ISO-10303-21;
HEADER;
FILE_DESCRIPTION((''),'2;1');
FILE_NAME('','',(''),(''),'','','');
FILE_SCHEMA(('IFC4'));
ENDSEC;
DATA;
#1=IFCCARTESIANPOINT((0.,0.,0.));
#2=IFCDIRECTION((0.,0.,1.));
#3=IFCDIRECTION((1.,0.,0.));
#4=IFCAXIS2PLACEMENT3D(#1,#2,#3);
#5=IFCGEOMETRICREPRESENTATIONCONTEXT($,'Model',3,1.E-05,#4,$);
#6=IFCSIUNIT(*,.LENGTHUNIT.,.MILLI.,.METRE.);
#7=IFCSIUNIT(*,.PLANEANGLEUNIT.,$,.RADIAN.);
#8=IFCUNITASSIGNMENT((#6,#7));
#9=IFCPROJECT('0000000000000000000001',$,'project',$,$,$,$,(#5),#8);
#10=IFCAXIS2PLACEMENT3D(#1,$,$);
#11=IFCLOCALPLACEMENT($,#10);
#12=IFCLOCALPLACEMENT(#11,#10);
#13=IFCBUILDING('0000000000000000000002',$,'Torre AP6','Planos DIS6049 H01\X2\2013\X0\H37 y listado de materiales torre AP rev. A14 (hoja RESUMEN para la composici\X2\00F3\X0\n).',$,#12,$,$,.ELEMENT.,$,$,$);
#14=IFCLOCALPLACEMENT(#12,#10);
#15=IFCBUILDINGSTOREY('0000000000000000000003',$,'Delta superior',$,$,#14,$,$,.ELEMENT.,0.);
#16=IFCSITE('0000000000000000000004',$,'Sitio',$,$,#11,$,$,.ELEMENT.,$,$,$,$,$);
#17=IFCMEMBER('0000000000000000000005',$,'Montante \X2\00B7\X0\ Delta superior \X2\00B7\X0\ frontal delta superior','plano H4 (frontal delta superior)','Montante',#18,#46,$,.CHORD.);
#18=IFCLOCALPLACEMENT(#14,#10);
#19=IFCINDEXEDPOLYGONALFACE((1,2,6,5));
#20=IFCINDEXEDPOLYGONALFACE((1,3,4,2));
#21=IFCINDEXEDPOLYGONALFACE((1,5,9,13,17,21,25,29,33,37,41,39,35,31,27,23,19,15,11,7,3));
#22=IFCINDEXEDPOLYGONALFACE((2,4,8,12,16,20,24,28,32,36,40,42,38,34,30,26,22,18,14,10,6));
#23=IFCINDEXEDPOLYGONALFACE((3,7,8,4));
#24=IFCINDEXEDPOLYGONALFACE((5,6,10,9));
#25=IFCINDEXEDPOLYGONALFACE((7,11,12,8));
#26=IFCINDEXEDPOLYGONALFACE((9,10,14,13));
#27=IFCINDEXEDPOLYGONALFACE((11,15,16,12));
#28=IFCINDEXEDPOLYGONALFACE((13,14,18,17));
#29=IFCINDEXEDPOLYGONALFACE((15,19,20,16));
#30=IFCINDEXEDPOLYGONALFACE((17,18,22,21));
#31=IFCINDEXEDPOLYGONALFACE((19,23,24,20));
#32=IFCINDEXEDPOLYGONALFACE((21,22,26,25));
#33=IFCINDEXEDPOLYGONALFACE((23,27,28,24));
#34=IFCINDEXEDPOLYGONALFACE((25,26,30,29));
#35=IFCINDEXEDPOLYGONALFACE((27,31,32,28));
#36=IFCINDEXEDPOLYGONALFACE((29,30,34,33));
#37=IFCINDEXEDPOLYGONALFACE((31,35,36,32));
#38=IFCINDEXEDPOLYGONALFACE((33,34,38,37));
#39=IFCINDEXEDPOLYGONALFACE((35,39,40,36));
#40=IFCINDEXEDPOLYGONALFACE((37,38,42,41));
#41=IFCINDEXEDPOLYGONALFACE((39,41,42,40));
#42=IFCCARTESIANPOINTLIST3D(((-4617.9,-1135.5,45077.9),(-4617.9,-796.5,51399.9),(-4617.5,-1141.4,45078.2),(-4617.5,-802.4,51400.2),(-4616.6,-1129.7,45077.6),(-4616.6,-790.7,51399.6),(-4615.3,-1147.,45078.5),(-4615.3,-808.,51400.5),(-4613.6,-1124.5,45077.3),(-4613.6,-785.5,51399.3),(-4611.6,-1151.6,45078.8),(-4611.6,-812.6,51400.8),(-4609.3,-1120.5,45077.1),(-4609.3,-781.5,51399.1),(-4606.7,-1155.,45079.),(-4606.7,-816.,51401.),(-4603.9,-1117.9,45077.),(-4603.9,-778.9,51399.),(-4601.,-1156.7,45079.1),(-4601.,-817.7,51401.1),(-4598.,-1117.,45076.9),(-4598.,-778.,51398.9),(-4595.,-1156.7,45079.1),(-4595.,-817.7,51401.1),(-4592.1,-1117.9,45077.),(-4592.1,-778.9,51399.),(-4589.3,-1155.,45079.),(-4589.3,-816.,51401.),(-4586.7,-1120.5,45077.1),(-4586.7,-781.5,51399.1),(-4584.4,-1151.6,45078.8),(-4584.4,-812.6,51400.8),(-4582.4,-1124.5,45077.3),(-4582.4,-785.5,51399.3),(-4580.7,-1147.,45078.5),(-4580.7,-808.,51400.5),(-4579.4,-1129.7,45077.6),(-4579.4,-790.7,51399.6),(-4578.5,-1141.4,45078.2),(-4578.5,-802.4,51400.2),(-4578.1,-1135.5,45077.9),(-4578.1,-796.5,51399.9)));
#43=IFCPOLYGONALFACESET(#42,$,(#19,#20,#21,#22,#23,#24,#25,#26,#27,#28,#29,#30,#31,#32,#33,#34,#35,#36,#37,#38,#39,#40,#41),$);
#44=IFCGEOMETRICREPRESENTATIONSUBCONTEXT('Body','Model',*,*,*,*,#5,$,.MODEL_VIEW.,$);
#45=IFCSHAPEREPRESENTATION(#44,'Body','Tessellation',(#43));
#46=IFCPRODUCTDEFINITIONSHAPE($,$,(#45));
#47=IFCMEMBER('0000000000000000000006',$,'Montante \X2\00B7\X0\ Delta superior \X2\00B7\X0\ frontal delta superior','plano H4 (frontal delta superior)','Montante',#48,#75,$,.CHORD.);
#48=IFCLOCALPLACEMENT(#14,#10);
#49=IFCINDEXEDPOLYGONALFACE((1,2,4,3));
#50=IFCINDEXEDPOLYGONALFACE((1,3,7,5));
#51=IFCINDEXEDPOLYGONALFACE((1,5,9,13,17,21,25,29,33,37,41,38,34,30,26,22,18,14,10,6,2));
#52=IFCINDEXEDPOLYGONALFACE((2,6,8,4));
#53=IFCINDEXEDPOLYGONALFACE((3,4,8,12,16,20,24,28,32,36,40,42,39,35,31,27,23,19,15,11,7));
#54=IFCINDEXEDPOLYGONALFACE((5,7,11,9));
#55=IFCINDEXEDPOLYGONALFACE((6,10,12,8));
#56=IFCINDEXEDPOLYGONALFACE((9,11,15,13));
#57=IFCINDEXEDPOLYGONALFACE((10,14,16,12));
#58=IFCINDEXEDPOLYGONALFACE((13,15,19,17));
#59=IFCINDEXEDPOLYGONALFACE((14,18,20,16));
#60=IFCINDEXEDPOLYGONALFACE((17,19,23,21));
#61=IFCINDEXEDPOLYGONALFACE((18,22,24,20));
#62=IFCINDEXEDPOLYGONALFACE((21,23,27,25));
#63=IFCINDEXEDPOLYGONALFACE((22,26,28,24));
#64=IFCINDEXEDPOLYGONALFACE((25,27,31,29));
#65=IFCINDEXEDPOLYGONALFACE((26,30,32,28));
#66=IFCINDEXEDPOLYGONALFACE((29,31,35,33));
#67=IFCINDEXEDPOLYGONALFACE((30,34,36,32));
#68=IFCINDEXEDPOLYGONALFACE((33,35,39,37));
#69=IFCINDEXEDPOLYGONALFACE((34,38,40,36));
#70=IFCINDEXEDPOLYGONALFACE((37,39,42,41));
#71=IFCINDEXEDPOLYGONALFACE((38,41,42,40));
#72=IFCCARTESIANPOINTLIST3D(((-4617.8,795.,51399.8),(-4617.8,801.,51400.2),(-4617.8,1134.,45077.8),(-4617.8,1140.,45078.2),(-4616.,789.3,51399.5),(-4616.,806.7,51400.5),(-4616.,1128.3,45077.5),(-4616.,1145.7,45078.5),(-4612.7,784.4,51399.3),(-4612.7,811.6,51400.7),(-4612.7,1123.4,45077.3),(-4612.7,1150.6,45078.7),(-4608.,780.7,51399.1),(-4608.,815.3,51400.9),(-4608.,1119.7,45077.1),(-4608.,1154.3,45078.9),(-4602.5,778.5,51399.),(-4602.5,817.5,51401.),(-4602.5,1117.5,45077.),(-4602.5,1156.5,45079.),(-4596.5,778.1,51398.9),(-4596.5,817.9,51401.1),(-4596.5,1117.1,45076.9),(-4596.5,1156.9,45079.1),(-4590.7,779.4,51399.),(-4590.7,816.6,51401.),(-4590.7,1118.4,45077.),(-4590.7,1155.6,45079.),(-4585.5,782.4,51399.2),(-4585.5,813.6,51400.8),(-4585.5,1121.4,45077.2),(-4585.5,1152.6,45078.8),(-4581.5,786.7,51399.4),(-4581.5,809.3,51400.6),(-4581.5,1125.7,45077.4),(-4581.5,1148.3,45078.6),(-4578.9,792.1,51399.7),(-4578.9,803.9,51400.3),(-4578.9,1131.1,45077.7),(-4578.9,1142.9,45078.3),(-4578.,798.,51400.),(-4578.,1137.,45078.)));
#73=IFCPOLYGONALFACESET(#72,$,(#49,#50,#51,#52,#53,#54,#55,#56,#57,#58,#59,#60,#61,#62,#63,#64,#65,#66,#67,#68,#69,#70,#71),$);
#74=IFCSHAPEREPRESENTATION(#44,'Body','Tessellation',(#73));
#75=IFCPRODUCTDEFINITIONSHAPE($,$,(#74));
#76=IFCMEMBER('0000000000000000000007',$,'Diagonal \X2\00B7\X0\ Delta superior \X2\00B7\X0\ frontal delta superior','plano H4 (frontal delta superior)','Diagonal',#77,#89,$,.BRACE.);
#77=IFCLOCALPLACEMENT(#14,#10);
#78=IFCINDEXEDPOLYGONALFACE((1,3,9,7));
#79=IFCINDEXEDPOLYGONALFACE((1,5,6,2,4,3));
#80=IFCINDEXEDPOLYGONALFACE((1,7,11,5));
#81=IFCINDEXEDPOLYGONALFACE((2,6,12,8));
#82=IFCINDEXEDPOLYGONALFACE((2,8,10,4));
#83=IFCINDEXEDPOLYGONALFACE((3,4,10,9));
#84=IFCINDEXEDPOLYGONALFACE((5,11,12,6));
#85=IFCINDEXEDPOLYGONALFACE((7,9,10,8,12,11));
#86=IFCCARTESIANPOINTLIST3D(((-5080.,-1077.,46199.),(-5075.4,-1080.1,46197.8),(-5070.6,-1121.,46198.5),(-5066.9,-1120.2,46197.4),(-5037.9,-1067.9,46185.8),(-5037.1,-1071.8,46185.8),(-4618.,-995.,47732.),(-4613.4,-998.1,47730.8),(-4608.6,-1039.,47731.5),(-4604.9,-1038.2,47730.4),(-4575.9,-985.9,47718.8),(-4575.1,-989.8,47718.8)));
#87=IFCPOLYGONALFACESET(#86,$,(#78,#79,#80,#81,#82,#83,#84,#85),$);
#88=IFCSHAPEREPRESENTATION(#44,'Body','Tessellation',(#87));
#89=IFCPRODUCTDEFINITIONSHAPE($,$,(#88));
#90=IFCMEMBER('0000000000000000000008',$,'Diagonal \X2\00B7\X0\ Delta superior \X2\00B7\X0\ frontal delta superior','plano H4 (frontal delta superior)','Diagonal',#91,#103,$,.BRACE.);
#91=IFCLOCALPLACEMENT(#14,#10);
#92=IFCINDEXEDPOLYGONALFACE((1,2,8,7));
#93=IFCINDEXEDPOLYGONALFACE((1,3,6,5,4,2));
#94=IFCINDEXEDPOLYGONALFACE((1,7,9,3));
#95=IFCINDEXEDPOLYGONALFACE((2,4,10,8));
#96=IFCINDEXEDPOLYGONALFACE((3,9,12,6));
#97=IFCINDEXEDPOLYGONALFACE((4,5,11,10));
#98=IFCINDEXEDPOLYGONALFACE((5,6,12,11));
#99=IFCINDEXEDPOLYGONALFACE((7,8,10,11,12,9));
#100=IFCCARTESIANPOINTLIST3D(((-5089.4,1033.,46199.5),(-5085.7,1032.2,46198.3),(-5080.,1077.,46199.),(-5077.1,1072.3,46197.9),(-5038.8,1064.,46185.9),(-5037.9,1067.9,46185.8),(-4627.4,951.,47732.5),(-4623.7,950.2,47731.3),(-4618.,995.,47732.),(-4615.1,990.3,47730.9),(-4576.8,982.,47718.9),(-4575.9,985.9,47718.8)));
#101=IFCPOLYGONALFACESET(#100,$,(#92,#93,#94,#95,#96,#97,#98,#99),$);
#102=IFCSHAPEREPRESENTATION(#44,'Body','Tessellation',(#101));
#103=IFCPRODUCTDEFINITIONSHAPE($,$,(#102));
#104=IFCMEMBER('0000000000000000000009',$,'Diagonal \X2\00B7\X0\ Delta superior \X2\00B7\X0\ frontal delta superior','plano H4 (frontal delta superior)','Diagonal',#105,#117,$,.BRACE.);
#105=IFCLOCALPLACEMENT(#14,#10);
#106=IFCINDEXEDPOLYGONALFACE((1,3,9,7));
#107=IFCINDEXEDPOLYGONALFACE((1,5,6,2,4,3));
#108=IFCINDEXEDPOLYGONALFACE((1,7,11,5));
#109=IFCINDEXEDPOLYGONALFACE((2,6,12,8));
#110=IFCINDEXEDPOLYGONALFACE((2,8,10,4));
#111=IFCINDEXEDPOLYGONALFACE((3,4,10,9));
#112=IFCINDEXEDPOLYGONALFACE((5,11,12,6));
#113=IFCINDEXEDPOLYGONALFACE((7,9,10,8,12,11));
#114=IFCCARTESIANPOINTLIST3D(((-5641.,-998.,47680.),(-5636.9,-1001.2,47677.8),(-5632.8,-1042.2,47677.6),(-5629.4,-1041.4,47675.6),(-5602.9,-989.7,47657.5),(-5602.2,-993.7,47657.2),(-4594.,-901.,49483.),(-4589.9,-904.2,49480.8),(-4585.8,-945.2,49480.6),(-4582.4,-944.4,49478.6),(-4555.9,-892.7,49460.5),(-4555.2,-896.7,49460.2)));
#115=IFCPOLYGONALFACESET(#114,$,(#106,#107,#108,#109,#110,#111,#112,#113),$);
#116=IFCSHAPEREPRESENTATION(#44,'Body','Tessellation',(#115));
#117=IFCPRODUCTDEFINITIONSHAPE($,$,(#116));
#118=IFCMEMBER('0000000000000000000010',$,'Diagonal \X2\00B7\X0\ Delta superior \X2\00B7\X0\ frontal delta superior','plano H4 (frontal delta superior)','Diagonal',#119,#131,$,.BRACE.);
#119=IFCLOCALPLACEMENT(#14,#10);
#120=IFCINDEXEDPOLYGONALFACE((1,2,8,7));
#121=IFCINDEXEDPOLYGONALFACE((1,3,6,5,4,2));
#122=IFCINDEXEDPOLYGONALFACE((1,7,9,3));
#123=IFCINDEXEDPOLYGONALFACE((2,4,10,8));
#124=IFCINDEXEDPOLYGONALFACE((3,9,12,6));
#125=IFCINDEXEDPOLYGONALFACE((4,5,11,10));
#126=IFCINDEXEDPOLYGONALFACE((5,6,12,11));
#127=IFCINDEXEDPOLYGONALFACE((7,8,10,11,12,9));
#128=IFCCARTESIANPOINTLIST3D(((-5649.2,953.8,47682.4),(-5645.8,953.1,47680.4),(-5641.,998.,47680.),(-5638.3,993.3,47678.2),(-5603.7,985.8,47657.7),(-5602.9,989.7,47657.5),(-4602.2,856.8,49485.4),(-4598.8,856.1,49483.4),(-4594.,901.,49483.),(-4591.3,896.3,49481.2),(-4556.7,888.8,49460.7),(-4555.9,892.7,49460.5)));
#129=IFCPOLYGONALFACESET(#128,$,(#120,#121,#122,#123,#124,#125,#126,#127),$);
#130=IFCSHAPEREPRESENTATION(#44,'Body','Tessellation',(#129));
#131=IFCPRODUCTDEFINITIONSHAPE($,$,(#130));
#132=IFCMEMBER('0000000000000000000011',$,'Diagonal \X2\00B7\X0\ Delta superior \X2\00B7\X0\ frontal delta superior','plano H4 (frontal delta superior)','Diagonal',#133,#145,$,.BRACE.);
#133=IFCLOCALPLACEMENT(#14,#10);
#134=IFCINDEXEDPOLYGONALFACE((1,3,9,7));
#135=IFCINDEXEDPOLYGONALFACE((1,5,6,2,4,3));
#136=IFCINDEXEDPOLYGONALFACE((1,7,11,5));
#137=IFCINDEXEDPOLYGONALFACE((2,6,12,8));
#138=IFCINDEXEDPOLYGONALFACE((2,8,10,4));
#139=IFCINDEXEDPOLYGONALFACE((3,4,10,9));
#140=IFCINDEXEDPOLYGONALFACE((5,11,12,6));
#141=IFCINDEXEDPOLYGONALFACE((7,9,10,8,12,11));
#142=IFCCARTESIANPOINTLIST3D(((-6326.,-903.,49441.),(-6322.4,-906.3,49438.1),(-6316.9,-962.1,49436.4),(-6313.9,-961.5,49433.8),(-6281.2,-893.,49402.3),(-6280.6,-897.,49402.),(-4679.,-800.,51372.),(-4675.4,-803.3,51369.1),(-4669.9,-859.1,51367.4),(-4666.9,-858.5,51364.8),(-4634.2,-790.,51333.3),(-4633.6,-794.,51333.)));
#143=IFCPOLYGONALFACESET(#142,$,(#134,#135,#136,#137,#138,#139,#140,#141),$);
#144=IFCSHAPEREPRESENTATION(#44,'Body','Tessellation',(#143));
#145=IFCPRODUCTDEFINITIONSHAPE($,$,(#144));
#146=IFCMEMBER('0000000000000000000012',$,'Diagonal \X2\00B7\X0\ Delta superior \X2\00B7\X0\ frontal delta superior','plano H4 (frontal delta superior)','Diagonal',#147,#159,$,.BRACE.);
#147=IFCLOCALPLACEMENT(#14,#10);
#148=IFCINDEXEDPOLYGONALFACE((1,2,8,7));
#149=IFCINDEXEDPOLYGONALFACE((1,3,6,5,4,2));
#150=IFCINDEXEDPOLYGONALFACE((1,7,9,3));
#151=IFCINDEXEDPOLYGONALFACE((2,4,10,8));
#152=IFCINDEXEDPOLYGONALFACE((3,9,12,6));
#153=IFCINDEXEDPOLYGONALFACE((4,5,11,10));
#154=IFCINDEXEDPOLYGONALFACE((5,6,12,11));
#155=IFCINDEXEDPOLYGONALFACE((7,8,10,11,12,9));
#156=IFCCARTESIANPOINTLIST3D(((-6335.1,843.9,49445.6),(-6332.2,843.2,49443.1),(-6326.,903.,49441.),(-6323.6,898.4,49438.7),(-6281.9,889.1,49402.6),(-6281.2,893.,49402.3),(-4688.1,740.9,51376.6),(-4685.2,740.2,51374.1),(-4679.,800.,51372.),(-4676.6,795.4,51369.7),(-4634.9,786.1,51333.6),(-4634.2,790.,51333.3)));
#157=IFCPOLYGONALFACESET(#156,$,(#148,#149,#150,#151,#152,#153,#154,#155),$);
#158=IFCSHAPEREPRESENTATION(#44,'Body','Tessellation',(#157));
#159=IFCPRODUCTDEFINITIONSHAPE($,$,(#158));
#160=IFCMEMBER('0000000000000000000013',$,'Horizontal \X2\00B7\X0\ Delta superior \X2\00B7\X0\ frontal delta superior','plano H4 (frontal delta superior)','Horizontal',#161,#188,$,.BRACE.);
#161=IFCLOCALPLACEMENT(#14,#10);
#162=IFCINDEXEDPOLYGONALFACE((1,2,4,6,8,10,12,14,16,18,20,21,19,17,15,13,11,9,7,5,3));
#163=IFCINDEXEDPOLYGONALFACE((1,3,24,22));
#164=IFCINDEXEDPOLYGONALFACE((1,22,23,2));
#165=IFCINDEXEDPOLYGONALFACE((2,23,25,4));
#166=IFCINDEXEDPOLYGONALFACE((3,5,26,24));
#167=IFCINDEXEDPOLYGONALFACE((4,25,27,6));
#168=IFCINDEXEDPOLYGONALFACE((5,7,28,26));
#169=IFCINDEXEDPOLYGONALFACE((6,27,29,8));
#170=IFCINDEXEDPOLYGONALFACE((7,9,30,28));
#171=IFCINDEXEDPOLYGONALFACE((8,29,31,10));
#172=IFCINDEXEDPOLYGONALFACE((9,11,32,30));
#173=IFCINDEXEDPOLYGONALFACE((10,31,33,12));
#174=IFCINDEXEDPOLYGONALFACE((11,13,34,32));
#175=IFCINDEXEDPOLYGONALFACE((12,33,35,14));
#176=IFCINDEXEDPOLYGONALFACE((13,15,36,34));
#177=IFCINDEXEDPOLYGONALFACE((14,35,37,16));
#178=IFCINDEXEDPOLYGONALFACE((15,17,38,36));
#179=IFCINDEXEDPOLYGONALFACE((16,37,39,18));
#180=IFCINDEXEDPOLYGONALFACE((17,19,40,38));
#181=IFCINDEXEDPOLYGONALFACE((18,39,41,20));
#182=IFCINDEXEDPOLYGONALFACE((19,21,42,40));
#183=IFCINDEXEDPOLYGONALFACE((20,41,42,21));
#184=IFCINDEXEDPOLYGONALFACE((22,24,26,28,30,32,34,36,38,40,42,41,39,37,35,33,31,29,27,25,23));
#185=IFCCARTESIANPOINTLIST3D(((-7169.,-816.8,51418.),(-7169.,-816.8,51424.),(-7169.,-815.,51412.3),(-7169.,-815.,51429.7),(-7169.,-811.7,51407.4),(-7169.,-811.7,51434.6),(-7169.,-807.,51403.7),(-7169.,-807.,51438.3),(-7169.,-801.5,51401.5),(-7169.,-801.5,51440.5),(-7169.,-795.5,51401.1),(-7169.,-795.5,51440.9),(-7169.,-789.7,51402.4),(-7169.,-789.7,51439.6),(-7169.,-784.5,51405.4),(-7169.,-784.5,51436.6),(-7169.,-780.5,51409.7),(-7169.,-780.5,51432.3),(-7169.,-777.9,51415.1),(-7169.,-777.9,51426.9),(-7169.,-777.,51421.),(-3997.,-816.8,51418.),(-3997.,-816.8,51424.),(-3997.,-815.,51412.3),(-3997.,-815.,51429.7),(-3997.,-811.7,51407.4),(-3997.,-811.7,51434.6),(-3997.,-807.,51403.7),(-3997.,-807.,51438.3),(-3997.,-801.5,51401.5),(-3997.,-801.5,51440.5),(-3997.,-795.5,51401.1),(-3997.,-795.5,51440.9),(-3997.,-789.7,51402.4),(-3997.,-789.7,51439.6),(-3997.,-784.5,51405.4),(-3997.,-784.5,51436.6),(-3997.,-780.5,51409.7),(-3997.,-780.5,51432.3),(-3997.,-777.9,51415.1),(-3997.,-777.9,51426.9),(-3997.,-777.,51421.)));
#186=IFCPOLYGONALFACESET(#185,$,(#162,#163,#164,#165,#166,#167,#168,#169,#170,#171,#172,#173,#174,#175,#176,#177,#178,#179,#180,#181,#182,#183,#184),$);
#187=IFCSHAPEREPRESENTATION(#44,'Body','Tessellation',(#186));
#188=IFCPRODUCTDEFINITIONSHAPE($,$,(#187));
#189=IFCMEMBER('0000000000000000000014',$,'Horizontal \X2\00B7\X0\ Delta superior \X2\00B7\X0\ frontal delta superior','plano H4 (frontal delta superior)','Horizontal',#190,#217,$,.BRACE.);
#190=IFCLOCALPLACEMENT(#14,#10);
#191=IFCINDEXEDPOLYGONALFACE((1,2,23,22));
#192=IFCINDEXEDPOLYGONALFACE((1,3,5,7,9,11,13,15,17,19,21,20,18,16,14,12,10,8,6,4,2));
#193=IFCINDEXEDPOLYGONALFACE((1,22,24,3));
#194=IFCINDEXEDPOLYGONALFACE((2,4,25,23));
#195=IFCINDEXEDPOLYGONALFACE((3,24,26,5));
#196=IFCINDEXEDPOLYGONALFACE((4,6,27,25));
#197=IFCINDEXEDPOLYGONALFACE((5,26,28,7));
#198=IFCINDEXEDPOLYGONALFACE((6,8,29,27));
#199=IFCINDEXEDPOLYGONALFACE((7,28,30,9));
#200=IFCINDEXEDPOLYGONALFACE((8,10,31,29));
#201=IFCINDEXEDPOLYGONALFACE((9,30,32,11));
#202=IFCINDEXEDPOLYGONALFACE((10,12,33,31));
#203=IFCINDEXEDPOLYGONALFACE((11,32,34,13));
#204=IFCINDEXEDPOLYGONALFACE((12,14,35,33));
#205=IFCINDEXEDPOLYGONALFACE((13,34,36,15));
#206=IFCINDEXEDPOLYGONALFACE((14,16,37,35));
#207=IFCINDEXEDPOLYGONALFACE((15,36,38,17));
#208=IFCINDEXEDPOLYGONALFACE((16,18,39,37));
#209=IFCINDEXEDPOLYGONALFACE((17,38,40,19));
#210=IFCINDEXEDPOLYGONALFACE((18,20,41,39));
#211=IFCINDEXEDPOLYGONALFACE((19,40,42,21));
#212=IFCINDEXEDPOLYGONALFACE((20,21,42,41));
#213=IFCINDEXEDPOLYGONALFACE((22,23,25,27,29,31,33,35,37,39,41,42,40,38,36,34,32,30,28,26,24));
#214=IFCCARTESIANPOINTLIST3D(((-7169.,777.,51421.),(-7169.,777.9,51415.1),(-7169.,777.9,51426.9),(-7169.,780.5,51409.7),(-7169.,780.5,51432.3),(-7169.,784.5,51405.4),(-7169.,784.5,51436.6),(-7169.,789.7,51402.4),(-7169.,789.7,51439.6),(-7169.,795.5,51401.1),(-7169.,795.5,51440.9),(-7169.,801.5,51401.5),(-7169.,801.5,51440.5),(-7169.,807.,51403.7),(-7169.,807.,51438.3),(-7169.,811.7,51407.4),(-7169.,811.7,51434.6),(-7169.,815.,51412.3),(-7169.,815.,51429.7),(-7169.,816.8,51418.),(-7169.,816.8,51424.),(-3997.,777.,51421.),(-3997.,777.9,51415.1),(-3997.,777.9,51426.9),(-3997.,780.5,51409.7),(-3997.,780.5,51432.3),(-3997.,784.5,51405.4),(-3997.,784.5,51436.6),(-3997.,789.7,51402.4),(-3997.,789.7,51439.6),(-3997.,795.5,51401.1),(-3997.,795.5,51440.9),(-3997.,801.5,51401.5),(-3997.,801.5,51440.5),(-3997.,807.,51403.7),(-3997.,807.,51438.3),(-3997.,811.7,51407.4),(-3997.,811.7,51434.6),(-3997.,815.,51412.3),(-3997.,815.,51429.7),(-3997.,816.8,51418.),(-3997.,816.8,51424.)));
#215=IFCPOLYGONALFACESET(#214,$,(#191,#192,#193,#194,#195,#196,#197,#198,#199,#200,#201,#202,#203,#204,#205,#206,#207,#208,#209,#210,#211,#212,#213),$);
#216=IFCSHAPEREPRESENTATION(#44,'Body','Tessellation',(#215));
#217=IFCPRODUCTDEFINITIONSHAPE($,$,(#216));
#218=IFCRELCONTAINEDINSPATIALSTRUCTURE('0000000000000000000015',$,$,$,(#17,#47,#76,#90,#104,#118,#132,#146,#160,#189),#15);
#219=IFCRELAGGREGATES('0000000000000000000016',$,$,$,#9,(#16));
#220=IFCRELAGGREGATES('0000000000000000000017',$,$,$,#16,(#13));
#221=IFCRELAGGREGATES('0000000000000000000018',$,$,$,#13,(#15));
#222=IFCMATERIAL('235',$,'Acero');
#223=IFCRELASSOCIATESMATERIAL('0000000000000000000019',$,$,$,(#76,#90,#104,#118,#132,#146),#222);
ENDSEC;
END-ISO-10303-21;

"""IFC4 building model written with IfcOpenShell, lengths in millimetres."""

from ifc_helpers import new_model, si_unit, frame, frame_2d, origin, origin_with_axes, place, context, subcontext, project, spatial, circle, l_section, extrude, material, element, save


model = new_model("IFC4")

# Units and contexts
model_context = context("Model", 3, precision=1e-05, world=origin_with_axes())
body_context = subcontext(model_context, "Body", "Model", "MODEL_VIEW")
ifc_project = project(units=[si_unit("LENGTHUNIT", "METRE", prefix="MILLI"), si_unit("PLANEANGLEUNIT", "RADIAN")], contexts=[model_context])

# Site, building, storey
site_placement = place(None, origin())
site = spatial("IfcSite", under=ifc_project, at=site_placement, Name="Sitio", CompositionType="ELEMENT")
building_placement = place(site_placement, origin())
building = spatial("IfcBuilding", under=site, at=building_placement, Name="Torre AP6", Description="Planos DIS6049 H01–H37 y listado de materiales torre AP rev. A14 (hoja RESUMEN para la composición).", CompositionType="ELEMENT")
storey_placement = place(building_placement, origin())
storey = spatial("IfcBuildingStorey", under=building, at=storey_placement, Name="Delta superior", CompositionType="ELEMENT", Elevation=0.0)

# Members
for number, where, z_axis, x_axis, name in (
    (1, (-4598.0, -798.0, 51400.0), (0.0, -0.053545, -0.998565), (0.0, 0.998565, -0.053545), "Montante · Delta superior · frontal delta superior"),
    (2, (-4598.0, 798.0, 51400.0), (0.0, 0.053545, -0.998565), (1.0, 0.0, 0.0), "Montante · Delta superior · frontal delta superior"),
):
    element("IfcMember", number, at=place(storey_placement, frame(where, z_axis=z_axis, x_axis=x_axis)), inside=storey, Name=name, Description="plano H4 (frontal delta superior)", ObjectType="Montante", PredefinedType="CHORD", context=body_context, shape_type="SweptSolid", body=[
        extrude(circle(Radius=20.0), None, (0.0, 0.0, 1.0), 6331.1),
    ])
ifc_material_1 = material(Name="235", Category="Acero")
for number, where, z_axis, x_axis, name in (
    (3, (-4618.0, -995.0, 47732.0), (-0.288173, -0.051148, -0.956211), (0.934509, 0.202848, -0.292483), "Diagonal · Delta superior · frontal delta superior"),
    (4, (-4618.0, 995.0, 47732.0), (-0.288173, 0.051148, -0.956211), (0.934509, -0.202848, -0.292483), "Diagonal · Delta superior · frontal delta superior"),
):
    element("IfcMember", number, at=place(storey_placement, frame(where, z_axis=z_axis, x_axis=x_axis)), inside=storey, material=ifc_material_1, Name=name, Description="plano H4 (frontal delta superior)", ObjectType="Diagonal", PredefinedType="BRACE", context=body_context, shape_type="SweptSolid", body=[
        extrude(l_section(Depth=45.0, Width=45.0, Thickness=4.0, at=frame_2d((22.5, 22.5))), None, (0.0, 0.0, 1.0), 1603.2),
    ])
for number, where, z_axis, x_axis, name in (
    (5, (-4594.0, -901.0, 49483.0), (-0.501628, -0.046474, -0.863834), (0.845685, 0.183933, -0.500984), "Diagonal · Delta superior · frontal delta superior"),
    (6, (-4594.0, 901.0, 49483.0), (-0.501628, 0.046474, -0.863834), (0.845685, -0.183933, -0.500984), "Diagonal · Delta superior · frontal delta superior"),
):
    element("IfcMember", number, at=place(storey_placement, frame(where, z_axis=z_axis, x_axis=x_axis)), inside=storey, material=ifc_material_1, Name=name, Description="plano H4 (frontal delta superior)", ObjectType="Diagonal", PredefinedType="BRACE", context=body_context, shape_type="SweptSolid", body=[
        extrude(l_section(Depth=45.0, Width=45.0, Thickness=4.0, at=frame_2d((22.5, 22.5))), None, (0.0, 0.0, 1.0), 2087.2),
    ])
for number, where, z_axis, x_axis, name in (
    (7, (-4679.0, -800.0, 51372.0), (-0.648406, -0.04055, -0.760214), (0.745871, 0.166153, -0.645035), "Diagonal · Delta superior · frontal delta superior"),
    (8, (-4679.0, 800.0, 51372.0), (-0.648406, 0.04055, -0.760214), (0.745871, -0.166153, -0.645035), "Diagonal · Delta superior · frontal delta superior"),
):
    element("IfcMember", number, at=place(storey_placement, frame(where, z_axis=z_axis, x_axis=x_axis)), inside=storey, material=ifc_material_1, Name=name, Description="plano H4 (frontal delta superior)", ObjectType="Diagonal", PredefinedType="BRACE", context=body_context, shape_type="SweptSolid", body=[
        extrude(l_section(Depth=60.0, Width=60.0, Thickness=4.0, at=frame_2d((30.0, 30.0))), None, (0.0, 0.0, 1.0), 2540.1),
    ])
for number, where, z_axis, x_axis, name in (
    (9, (-3997.0, -797.0, 51421.0), (-1.0, 0.0, 0.0), (0.0, 1.0, 0.0), "Horizontal · Delta superior · frontal delta superior"),
    (10, (-3997.0, 797.0, 51421.0), (-1.0, 0.0, 0.0), (0.0, -1.0, 0.0), "Horizontal · Delta superior · frontal delta superior"),
):
    element("IfcMember", number, at=place(storey_placement, frame(where, z_axis=z_axis, x_axis=x_axis)), inside=storey, Name=name, Description="plano H4 (frontal delta superior)", ObjectType="Horizontal", PredefinedType="BRACE", context=body_context, shape_type="SweptSolid", body=[
        extrude(circle(Radius=20.0), None, (0.0, 0.0, 1.0), 3172.0),
    ])

save(model, "model.ifc")
